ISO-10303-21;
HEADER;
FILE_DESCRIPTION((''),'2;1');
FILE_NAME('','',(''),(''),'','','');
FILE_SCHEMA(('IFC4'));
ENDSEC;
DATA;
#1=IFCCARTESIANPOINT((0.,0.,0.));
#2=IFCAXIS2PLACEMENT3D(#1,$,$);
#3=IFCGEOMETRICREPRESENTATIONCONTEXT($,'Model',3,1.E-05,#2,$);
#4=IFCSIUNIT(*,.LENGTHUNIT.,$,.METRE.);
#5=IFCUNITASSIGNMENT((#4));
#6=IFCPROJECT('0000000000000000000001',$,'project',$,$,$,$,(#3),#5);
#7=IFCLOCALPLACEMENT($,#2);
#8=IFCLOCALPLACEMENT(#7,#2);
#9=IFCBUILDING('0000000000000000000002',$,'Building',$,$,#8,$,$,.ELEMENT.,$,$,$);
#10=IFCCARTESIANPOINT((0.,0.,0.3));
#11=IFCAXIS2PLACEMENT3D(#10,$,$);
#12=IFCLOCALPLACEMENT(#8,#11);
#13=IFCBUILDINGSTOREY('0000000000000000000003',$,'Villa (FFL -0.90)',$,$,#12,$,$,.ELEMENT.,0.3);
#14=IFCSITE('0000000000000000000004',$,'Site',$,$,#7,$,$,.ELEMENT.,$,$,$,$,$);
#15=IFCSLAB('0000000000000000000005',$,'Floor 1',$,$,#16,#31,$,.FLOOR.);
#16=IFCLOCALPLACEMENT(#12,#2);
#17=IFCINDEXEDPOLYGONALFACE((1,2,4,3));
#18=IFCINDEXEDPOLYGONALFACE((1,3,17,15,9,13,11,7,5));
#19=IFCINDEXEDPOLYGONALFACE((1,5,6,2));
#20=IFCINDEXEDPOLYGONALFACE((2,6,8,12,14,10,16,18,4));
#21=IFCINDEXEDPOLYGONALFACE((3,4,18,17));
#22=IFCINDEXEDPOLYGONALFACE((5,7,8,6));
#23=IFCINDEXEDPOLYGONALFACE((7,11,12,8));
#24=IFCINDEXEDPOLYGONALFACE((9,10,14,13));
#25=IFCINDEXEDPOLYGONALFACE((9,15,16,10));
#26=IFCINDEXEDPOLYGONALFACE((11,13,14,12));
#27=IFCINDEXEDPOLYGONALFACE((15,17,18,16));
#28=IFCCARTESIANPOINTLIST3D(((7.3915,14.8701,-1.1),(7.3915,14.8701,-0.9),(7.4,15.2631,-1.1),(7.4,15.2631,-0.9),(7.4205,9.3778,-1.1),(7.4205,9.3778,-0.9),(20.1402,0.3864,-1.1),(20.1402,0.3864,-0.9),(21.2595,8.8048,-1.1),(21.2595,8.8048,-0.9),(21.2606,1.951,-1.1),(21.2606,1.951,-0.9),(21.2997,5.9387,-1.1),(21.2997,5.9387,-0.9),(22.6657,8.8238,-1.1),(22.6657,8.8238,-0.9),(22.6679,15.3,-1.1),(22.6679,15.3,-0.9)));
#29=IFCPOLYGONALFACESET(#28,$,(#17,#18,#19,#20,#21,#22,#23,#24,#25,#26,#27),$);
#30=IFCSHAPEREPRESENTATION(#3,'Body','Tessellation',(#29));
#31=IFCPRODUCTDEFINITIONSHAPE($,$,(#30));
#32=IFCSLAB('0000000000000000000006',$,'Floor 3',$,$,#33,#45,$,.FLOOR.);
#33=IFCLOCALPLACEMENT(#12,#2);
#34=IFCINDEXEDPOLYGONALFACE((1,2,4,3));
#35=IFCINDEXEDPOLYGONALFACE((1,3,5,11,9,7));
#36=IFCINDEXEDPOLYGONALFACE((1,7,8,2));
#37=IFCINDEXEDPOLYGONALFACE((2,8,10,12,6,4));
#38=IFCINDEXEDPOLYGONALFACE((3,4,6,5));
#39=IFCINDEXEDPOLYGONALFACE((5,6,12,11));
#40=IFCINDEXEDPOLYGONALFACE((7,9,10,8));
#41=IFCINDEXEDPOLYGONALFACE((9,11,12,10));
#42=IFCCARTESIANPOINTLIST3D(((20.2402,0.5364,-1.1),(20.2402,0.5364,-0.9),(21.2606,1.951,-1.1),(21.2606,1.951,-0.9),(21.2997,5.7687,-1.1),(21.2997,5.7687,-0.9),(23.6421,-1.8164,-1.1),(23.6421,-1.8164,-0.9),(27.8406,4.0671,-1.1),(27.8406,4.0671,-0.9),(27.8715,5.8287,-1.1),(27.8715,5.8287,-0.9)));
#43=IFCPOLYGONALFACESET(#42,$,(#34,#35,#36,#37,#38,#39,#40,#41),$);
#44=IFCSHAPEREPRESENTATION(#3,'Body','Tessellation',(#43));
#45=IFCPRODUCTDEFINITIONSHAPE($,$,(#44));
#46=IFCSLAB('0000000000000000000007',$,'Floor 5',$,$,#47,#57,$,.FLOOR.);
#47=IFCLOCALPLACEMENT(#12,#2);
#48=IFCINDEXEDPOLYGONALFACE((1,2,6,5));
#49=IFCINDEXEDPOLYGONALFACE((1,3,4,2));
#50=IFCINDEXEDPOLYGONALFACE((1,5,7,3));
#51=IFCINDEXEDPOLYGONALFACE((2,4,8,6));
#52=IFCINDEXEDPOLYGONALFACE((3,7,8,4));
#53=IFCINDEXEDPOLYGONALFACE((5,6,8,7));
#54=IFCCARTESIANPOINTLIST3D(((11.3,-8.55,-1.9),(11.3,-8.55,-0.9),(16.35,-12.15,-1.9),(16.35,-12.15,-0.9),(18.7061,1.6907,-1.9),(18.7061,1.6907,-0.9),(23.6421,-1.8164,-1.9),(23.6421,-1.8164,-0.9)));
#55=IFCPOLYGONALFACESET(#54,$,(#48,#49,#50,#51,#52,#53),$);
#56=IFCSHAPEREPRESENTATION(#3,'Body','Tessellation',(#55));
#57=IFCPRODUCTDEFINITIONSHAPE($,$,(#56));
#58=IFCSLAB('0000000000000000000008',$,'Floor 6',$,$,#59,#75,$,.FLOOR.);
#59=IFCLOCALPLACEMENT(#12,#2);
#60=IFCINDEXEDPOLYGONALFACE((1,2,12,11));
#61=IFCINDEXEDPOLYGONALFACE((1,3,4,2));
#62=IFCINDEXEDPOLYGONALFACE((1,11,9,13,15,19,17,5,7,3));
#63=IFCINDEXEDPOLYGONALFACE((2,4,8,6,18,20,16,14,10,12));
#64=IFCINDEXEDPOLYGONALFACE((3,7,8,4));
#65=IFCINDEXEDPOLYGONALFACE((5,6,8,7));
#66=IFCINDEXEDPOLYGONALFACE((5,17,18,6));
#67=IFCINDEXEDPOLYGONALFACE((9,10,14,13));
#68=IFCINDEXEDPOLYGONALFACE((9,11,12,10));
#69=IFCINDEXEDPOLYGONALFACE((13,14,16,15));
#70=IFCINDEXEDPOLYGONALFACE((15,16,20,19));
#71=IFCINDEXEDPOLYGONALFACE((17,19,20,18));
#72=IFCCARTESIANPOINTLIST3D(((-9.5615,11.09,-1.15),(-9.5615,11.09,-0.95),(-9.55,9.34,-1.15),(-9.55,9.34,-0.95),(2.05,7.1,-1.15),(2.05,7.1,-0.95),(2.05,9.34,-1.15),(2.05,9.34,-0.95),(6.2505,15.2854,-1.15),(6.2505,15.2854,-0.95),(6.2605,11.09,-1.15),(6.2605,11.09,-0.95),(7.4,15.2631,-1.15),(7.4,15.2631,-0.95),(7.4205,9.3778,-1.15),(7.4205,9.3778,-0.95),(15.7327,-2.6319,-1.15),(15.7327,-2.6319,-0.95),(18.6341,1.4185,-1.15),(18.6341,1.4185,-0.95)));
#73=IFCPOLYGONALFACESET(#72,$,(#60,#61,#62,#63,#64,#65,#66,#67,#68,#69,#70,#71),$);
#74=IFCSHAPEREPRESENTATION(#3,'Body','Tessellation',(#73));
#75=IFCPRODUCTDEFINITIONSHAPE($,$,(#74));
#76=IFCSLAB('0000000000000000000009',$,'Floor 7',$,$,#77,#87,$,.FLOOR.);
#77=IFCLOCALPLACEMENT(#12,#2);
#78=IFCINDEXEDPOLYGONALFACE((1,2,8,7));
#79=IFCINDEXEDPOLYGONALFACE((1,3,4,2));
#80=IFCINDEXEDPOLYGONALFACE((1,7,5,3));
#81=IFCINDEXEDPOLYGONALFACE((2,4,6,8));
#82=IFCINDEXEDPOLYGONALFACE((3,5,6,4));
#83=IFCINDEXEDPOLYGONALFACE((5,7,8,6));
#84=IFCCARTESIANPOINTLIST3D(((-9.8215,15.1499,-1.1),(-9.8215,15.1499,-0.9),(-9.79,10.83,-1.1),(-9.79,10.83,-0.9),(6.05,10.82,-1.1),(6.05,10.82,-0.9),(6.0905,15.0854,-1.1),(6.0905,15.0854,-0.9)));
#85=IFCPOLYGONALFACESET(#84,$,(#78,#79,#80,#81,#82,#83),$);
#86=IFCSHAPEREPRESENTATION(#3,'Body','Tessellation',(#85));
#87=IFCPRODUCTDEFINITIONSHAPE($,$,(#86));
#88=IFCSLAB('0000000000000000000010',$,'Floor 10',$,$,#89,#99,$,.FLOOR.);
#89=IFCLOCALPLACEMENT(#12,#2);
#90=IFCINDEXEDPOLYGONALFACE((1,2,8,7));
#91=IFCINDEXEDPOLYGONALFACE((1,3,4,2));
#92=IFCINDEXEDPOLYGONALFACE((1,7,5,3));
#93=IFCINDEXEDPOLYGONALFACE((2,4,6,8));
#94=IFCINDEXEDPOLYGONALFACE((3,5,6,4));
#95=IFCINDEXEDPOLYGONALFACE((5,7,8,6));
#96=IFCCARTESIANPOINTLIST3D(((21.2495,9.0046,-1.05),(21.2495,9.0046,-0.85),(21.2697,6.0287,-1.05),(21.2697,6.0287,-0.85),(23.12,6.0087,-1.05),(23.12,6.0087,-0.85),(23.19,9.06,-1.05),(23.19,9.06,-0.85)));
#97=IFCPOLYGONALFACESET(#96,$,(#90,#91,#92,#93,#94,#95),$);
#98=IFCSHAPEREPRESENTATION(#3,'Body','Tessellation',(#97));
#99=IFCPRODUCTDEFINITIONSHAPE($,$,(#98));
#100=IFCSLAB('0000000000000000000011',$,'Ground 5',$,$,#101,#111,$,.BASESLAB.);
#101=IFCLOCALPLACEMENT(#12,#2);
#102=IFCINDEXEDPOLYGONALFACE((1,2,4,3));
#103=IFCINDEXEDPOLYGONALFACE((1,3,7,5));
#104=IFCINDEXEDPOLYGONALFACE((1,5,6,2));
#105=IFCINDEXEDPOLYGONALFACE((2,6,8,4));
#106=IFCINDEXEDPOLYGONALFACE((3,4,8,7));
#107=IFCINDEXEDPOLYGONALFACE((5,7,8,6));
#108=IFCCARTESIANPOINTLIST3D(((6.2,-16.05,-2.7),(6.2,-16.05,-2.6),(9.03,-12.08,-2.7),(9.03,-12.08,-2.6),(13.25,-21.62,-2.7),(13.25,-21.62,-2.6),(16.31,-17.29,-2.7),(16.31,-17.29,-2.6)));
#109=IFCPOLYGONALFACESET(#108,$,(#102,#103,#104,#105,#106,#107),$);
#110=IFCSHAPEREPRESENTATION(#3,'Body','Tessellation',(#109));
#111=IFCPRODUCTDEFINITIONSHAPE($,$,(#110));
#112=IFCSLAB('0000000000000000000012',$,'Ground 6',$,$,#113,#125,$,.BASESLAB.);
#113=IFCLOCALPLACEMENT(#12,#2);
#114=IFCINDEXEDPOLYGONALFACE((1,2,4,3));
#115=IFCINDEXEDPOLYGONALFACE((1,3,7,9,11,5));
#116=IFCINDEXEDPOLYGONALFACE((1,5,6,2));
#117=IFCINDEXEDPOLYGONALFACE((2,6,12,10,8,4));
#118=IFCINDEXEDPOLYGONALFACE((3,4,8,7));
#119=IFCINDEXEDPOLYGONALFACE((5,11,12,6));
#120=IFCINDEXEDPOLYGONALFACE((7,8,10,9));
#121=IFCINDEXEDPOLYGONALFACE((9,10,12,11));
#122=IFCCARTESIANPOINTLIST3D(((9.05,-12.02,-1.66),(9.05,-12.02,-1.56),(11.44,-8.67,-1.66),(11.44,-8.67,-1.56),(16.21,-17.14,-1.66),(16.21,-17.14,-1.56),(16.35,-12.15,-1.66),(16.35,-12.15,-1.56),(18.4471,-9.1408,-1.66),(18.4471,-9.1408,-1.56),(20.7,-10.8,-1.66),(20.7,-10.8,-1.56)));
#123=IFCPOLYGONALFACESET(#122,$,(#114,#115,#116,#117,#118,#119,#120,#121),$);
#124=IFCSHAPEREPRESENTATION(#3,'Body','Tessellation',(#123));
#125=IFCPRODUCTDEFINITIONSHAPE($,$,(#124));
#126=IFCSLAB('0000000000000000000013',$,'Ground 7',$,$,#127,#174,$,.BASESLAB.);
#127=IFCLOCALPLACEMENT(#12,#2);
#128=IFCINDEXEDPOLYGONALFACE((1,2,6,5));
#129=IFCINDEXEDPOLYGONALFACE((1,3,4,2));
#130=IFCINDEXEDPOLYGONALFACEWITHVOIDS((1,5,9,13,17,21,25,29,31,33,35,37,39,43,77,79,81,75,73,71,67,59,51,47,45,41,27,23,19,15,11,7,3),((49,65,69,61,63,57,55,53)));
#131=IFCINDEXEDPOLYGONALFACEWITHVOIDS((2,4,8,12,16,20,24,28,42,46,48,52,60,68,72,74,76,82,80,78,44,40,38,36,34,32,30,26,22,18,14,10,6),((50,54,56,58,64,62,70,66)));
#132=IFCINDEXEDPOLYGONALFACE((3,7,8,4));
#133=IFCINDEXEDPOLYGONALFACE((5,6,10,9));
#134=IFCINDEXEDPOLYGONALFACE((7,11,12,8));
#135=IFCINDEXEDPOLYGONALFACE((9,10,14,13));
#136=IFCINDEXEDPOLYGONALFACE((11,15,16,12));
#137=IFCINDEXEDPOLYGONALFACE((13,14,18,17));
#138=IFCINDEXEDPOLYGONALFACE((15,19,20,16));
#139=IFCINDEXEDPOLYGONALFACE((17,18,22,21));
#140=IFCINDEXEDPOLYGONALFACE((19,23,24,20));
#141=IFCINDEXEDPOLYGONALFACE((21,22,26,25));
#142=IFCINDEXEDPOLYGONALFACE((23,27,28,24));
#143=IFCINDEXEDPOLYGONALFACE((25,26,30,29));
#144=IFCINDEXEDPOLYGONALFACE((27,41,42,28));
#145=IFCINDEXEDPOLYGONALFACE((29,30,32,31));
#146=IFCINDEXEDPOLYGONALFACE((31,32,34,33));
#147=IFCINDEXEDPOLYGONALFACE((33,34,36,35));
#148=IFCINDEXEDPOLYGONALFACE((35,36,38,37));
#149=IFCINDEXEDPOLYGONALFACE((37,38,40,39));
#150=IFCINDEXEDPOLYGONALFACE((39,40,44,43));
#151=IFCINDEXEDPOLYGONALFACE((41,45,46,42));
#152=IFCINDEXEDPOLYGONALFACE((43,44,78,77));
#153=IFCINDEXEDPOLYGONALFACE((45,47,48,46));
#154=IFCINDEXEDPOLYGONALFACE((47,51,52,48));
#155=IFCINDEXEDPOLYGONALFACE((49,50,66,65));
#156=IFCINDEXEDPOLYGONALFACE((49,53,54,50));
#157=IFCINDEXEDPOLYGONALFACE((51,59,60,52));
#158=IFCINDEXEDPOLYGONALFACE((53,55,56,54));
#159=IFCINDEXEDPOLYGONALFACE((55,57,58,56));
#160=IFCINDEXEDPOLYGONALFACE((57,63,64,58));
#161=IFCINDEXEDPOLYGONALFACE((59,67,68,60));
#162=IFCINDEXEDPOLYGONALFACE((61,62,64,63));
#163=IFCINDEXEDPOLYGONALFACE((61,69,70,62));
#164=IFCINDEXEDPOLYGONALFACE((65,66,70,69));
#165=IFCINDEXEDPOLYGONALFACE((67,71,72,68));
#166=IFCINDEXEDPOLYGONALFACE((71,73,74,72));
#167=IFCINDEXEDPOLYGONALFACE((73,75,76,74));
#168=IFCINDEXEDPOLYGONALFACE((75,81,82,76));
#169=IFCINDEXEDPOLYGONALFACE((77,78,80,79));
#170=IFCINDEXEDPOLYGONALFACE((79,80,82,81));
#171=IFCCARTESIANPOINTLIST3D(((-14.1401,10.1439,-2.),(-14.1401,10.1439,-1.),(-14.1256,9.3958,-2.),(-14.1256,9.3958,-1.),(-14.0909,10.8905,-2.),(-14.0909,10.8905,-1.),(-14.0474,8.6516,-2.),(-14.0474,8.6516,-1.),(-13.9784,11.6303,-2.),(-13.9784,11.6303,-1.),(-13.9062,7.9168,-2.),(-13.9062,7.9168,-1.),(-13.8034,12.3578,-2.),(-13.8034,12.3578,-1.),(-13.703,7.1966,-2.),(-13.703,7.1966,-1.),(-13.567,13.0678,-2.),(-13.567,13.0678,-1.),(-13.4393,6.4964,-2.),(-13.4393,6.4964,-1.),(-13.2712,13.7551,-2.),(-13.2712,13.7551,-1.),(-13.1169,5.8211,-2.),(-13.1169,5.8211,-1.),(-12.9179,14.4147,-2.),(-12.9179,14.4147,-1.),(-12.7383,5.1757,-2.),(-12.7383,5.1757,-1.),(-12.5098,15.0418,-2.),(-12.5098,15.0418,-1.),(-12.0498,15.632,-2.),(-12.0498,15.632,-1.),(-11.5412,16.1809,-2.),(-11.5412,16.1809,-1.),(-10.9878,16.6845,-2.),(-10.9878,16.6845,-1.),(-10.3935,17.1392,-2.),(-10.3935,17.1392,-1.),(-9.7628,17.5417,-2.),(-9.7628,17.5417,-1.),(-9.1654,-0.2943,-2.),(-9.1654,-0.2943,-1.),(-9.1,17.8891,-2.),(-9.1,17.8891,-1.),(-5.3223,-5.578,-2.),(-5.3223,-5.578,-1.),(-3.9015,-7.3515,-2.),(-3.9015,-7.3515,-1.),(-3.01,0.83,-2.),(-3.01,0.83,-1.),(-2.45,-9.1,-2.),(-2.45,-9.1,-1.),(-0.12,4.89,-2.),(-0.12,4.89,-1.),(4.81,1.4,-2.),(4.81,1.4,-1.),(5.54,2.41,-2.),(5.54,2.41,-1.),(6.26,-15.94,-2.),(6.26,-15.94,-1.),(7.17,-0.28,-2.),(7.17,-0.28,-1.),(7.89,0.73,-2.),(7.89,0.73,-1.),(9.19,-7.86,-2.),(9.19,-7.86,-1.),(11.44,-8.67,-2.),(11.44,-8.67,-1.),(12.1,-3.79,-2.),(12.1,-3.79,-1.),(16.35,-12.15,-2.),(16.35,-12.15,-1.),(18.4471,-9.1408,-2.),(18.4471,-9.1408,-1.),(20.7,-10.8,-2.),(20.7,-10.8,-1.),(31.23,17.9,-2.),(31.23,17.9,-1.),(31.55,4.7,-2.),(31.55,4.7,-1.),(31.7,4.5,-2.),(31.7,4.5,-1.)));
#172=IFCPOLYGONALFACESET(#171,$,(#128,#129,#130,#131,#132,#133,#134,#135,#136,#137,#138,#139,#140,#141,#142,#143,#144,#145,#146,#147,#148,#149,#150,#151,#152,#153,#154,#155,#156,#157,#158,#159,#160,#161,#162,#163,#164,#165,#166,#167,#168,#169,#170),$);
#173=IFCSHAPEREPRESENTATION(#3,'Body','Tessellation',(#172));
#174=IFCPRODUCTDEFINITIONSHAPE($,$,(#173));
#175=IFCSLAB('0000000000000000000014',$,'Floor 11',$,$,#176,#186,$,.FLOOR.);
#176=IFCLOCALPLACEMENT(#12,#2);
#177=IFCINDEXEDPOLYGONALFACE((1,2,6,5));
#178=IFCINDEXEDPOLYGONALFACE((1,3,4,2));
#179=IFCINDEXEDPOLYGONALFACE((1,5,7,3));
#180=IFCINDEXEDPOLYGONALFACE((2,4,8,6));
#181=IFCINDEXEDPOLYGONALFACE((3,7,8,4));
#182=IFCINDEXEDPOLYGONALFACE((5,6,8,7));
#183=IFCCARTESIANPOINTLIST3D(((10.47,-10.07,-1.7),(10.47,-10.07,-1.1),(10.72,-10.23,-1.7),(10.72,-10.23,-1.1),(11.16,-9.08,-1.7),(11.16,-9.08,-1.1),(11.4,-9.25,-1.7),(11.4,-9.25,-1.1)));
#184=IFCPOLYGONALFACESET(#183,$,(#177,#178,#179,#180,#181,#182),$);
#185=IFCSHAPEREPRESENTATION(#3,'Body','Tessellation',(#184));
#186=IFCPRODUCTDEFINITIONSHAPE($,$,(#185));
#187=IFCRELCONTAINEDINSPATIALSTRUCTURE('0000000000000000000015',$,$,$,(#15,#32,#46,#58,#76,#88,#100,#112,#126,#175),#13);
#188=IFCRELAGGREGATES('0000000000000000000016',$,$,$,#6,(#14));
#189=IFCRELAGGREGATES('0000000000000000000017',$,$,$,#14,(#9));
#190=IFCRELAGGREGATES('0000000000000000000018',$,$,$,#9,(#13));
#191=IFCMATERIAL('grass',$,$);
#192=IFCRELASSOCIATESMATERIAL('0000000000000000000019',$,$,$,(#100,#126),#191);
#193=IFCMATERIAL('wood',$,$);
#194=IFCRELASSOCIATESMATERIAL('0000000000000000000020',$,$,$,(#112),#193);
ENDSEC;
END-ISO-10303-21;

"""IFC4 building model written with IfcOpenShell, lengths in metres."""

from ifc_helpers import new_model, si_unit, frame, origin, place, context, project, spatial, polyline, outline, extrude, material, element, save


model = new_model("IFC4")

# Units and contexts
model_context = context("Model", 3, precision=1e-05, world=origin())
ifc_project = project(units=[si_unit("LENGTHUNIT", "METRE")], contexts=[model_context])

# Site, building, storey
site_placement = place(None, origin())
site = spatial("IfcSite", under=ifc_project, at=site_placement, Name="Site", CompositionType="ELEMENT")
building_placement = place(site_placement, origin())
building = spatial("IfcBuilding", under=site, at=building_placement, Name="Building", CompositionType="ELEMENT")
storey_placement = place(building_placement, frame((0.0, 0.0, 0.3)))
storey = spatial("IfcBuildingStorey", under=building, at=storey_placement, Name="Villa (FFL -0.90)", CompositionType="ELEMENT", Elevation=0.3)

# Slabs
slab_1_placement = place(storey_placement, frame((0.0, 0.0, -1.1), z_axis=(0.0, 0.0, 1.0), x_axis=(1.0, 0.0, 0.0)))
element("IfcSlab", 1, at=slab_1_placement, inside=storey, Name="Floor 1", PredefinedType="FLOOR", context=model_context, shape_type="SweptSolid", body=[
    extrude(outline(polyline([(7.4, 15.2631), (7.3915, 14.8701), (7.4205, 9.3778), (20.1402, 0.3864), (21.2606, 1.951), (21.2997, 5.9387), (21.2595, 8.8048), (22.6657, 8.8238), (22.6679, 15.3), (7.4, 15.2631)])), origin(), (0.0, 0.0, 1.0), 0.2),
])
slab_2_placement = place(storey_placement, frame((0.0, 0.0, -1.1), z_axis=(0.0, 0.0, 1.0), x_axis=(1.0, 0.0, 0.0)))
element("IfcSlab", 2, at=slab_2_placement, inside=storey, Name="Floor 3", PredefinedType="FLOOR", context=model_context, shape_type="SweptSolid", body=[
    extrude(outline(polyline([(27.8406, 4.0671), (23.6421, -1.8164), (20.2402, 0.5364), (21.2606, 1.951), (21.2997, 5.7687), (27.8715, 5.8287), (27.8406, 4.0671)])), origin(), (0.0, 0.0, 1.0), 0.2),
])
slab_3_placement = place(storey_placement, frame((0.0, 0.0, -1.9), z_axis=(0.0, 0.0, 1.0), x_axis=(1.0, 0.0, 0.0)))
element("IfcSlab", 3, at=slab_3_placement, inside=storey, Name="Floor 5", PredefinedType="FLOOR", context=model_context, shape_type="SweptSolid", body=[
    extrude(outline(polyline([(18.7061, 1.6907), (11.3, -8.55), (16.35, -12.15), (23.6421, -1.8164), (18.7061, 1.6907)])), origin(), (0.0, 0.0, 1.0), 1.0),
])
slab_4_placement = place(storey_placement, frame((0.0, 0.0, -1.15), z_axis=(0.0, 0.0, 1.0), x_axis=(1.0, 0.0, 0.0)))
element("IfcSlab", 4, at=slab_4_placement, inside=storey, Name="Floor 6", PredefinedType="FLOOR", context=model_context, shape_type="SweptSolid", body=[
    extrude(outline(polyline([(18.6341, 1.4185), (15.7327, -2.6319), (2.05, 7.1), (2.05, 9.34), (-9.55, 9.34), (-9.5615, 11.09), (6.2605, 11.09), (6.2505, 15.2854), (7.4, 15.2631), (7.4205, 9.3778), (18.6341, 1.4185)])), origin(), (0.0, 0.0, 1.0), 0.2),
])
slab_5_placement = place(storey_placement, frame((0.0, 0.0, -1.1), z_axis=(0.0, 0.0, 1.0), x_axis=(1.0, 0.0, 0.0)))
element("IfcSlab", 5, at=slab_5_placement, inside=storey, Name="Floor 7", PredefinedType="FLOOR", context=model_context, shape_type="SweptSolid", body=[
    extrude(outline(polyline([(-9.8215, 15.1499), (6.0905, 15.0854), (6.05, 10.82), (-9.79, 10.83), (-9.8215, 15.1499)])), origin(), (0.0, 0.0, 1.0), 0.2),
])
slab_6_placement = place(storey_placement, frame((0.0, 0.0, -1.05), z_axis=(0.0, 0.0, 1.0), x_axis=(1.0, 0.0, 0.0)))
element("IfcSlab", 6, at=slab_6_placement, inside=storey, Name="Floor 10", PredefinedType="FLOOR", context=model_context, shape_type="SweptSolid", body=[
    extrude(outline(polyline([(21.2495, 9.0046), (21.2697, 6.0287), (23.12, 6.0087), (23.19, 9.06), (21.2495, 9.0046)])), origin(), (0.0, 0.0, 1.0), 0.2),
])
ifc_material_1 = material(Name="grass")
slab_7_placement = place(storey_placement, frame((0.0, 0.0, -2.7), z_axis=(0.0, 0.0, 1.0), x_axis=(1.0, 0.0, 0.0)))
element("IfcSlab", 7, at=slab_7_placement, inside=storey, material=ifc_material_1, Name="Ground 5", PredefinedType="BASESLAB", context=model_context, shape_type="SweptSolid", body=[
    extrude(outline(polyline([(9.03, -12.08), (16.31, -17.29), (13.25, -21.62), (6.2, -16.05), (9.03, -12.08)])), origin(), (0.0, 0.0, 1.0), 0.1),
])
ifc_material_2 = material(Name="wood")
slab_8_placement = place(storey_placement, frame((0.0, 0.0, -1.66), z_axis=(0.0, 0.0, 1.0), x_axis=(1.0, 0.0, 0.0)))
element("IfcSlab", 8, at=slab_8_placement, inside=storey, material=ifc_material_2, Name="Ground 6", PredefinedType="BASESLAB", context=model_context, shape_type="SweptSolid", body=[
    extrude(outline(polyline([(16.21, -17.14), (20.7, -10.8), (18.4471, -9.1408), (16.35, -12.15), (11.44, -8.67), (9.05, -12.02), (16.21, -17.14)])), origin(), (0.0, 0.0, 1.0), 0.1),
])
slab_9_placement = place(storey_placement, frame((0.0, 0.0, -2.0), z_axis=(0.0, 0.0, 1.0), x_axis=(1.0, 0.0, 0.0)))
element("IfcSlab", 9, at=slab_9_placement, inside=storey, material=ifc_material_1, Name="Ground 7", PredefinedType="BASESLAB", context=model_context, shape_type="SweptSolid", body=[
    extrude(outline(polyline([(31.23, 17.9), (31.55, 4.7), (31.7, 4.5), (20.7, -10.8), (18.4471, -9.1408), (16.35, -12.15), (11.44, -8.67), (6.26, -15.94), (-2.45, -9.1), (-3.9015, -7.3515), (-5.3223, -5.578), (-9.1654, -0.2943), (-12.7383, 5.1757), (-13.1169, 5.8211), (-13.4393, 6.4964), (-13.703, 7.1966), (-13.9062, 7.9168), (-14.0474, 8.6516), (-14.1256, 9.3958), (-14.1401, 10.1439), (-14.0909, 10.8905), (-13.9784, 11.6303), (-13.8034, 12.3578), (-13.567, 13.0678), (-13.2712, 13.7551), (-12.9179, 14.4147), (-12.5098, 15.0418), (-12.0498, 15.632), (-11.5412, 16.1809), (-10.9878, 16.6845), (-10.3935, 17.1392), (-9.7628, 17.5417), (-9.1, 17.8891), (31.23, 17.9)]), holes=[polyline([(-3.01, 0.83), (-0.12, 4.89), (4.81, 1.4), (5.54, 2.41), (7.89, 0.73), (7.17, -0.28), (12.1, -3.79), (9.19, -7.86), (-3.01, 0.83)])]), origin(), (0.0, 0.0, 1.0), 1.0),
])
slab_10_placement = place(storey_placement, frame((0.0, 0.0, -1.7), z_axis=(0.0, 0.0, 1.0), x_axis=(1.0, 0.0, 0.0)))
element("IfcSlab", 10, at=slab_10_placement, inside=storey, Name="Floor 11", PredefinedType="FLOOR", context=model_context, shape_type="SweptSolid", body=[
    extrude(outline(polyline([(10.47, -10.07), (10.72, -10.23), (11.4, -9.25), (11.16, -9.08), (10.47, -10.07)])), origin(), (0.0, 0.0, 1.0), 0.6),
])

save(model, "model.ifc")
